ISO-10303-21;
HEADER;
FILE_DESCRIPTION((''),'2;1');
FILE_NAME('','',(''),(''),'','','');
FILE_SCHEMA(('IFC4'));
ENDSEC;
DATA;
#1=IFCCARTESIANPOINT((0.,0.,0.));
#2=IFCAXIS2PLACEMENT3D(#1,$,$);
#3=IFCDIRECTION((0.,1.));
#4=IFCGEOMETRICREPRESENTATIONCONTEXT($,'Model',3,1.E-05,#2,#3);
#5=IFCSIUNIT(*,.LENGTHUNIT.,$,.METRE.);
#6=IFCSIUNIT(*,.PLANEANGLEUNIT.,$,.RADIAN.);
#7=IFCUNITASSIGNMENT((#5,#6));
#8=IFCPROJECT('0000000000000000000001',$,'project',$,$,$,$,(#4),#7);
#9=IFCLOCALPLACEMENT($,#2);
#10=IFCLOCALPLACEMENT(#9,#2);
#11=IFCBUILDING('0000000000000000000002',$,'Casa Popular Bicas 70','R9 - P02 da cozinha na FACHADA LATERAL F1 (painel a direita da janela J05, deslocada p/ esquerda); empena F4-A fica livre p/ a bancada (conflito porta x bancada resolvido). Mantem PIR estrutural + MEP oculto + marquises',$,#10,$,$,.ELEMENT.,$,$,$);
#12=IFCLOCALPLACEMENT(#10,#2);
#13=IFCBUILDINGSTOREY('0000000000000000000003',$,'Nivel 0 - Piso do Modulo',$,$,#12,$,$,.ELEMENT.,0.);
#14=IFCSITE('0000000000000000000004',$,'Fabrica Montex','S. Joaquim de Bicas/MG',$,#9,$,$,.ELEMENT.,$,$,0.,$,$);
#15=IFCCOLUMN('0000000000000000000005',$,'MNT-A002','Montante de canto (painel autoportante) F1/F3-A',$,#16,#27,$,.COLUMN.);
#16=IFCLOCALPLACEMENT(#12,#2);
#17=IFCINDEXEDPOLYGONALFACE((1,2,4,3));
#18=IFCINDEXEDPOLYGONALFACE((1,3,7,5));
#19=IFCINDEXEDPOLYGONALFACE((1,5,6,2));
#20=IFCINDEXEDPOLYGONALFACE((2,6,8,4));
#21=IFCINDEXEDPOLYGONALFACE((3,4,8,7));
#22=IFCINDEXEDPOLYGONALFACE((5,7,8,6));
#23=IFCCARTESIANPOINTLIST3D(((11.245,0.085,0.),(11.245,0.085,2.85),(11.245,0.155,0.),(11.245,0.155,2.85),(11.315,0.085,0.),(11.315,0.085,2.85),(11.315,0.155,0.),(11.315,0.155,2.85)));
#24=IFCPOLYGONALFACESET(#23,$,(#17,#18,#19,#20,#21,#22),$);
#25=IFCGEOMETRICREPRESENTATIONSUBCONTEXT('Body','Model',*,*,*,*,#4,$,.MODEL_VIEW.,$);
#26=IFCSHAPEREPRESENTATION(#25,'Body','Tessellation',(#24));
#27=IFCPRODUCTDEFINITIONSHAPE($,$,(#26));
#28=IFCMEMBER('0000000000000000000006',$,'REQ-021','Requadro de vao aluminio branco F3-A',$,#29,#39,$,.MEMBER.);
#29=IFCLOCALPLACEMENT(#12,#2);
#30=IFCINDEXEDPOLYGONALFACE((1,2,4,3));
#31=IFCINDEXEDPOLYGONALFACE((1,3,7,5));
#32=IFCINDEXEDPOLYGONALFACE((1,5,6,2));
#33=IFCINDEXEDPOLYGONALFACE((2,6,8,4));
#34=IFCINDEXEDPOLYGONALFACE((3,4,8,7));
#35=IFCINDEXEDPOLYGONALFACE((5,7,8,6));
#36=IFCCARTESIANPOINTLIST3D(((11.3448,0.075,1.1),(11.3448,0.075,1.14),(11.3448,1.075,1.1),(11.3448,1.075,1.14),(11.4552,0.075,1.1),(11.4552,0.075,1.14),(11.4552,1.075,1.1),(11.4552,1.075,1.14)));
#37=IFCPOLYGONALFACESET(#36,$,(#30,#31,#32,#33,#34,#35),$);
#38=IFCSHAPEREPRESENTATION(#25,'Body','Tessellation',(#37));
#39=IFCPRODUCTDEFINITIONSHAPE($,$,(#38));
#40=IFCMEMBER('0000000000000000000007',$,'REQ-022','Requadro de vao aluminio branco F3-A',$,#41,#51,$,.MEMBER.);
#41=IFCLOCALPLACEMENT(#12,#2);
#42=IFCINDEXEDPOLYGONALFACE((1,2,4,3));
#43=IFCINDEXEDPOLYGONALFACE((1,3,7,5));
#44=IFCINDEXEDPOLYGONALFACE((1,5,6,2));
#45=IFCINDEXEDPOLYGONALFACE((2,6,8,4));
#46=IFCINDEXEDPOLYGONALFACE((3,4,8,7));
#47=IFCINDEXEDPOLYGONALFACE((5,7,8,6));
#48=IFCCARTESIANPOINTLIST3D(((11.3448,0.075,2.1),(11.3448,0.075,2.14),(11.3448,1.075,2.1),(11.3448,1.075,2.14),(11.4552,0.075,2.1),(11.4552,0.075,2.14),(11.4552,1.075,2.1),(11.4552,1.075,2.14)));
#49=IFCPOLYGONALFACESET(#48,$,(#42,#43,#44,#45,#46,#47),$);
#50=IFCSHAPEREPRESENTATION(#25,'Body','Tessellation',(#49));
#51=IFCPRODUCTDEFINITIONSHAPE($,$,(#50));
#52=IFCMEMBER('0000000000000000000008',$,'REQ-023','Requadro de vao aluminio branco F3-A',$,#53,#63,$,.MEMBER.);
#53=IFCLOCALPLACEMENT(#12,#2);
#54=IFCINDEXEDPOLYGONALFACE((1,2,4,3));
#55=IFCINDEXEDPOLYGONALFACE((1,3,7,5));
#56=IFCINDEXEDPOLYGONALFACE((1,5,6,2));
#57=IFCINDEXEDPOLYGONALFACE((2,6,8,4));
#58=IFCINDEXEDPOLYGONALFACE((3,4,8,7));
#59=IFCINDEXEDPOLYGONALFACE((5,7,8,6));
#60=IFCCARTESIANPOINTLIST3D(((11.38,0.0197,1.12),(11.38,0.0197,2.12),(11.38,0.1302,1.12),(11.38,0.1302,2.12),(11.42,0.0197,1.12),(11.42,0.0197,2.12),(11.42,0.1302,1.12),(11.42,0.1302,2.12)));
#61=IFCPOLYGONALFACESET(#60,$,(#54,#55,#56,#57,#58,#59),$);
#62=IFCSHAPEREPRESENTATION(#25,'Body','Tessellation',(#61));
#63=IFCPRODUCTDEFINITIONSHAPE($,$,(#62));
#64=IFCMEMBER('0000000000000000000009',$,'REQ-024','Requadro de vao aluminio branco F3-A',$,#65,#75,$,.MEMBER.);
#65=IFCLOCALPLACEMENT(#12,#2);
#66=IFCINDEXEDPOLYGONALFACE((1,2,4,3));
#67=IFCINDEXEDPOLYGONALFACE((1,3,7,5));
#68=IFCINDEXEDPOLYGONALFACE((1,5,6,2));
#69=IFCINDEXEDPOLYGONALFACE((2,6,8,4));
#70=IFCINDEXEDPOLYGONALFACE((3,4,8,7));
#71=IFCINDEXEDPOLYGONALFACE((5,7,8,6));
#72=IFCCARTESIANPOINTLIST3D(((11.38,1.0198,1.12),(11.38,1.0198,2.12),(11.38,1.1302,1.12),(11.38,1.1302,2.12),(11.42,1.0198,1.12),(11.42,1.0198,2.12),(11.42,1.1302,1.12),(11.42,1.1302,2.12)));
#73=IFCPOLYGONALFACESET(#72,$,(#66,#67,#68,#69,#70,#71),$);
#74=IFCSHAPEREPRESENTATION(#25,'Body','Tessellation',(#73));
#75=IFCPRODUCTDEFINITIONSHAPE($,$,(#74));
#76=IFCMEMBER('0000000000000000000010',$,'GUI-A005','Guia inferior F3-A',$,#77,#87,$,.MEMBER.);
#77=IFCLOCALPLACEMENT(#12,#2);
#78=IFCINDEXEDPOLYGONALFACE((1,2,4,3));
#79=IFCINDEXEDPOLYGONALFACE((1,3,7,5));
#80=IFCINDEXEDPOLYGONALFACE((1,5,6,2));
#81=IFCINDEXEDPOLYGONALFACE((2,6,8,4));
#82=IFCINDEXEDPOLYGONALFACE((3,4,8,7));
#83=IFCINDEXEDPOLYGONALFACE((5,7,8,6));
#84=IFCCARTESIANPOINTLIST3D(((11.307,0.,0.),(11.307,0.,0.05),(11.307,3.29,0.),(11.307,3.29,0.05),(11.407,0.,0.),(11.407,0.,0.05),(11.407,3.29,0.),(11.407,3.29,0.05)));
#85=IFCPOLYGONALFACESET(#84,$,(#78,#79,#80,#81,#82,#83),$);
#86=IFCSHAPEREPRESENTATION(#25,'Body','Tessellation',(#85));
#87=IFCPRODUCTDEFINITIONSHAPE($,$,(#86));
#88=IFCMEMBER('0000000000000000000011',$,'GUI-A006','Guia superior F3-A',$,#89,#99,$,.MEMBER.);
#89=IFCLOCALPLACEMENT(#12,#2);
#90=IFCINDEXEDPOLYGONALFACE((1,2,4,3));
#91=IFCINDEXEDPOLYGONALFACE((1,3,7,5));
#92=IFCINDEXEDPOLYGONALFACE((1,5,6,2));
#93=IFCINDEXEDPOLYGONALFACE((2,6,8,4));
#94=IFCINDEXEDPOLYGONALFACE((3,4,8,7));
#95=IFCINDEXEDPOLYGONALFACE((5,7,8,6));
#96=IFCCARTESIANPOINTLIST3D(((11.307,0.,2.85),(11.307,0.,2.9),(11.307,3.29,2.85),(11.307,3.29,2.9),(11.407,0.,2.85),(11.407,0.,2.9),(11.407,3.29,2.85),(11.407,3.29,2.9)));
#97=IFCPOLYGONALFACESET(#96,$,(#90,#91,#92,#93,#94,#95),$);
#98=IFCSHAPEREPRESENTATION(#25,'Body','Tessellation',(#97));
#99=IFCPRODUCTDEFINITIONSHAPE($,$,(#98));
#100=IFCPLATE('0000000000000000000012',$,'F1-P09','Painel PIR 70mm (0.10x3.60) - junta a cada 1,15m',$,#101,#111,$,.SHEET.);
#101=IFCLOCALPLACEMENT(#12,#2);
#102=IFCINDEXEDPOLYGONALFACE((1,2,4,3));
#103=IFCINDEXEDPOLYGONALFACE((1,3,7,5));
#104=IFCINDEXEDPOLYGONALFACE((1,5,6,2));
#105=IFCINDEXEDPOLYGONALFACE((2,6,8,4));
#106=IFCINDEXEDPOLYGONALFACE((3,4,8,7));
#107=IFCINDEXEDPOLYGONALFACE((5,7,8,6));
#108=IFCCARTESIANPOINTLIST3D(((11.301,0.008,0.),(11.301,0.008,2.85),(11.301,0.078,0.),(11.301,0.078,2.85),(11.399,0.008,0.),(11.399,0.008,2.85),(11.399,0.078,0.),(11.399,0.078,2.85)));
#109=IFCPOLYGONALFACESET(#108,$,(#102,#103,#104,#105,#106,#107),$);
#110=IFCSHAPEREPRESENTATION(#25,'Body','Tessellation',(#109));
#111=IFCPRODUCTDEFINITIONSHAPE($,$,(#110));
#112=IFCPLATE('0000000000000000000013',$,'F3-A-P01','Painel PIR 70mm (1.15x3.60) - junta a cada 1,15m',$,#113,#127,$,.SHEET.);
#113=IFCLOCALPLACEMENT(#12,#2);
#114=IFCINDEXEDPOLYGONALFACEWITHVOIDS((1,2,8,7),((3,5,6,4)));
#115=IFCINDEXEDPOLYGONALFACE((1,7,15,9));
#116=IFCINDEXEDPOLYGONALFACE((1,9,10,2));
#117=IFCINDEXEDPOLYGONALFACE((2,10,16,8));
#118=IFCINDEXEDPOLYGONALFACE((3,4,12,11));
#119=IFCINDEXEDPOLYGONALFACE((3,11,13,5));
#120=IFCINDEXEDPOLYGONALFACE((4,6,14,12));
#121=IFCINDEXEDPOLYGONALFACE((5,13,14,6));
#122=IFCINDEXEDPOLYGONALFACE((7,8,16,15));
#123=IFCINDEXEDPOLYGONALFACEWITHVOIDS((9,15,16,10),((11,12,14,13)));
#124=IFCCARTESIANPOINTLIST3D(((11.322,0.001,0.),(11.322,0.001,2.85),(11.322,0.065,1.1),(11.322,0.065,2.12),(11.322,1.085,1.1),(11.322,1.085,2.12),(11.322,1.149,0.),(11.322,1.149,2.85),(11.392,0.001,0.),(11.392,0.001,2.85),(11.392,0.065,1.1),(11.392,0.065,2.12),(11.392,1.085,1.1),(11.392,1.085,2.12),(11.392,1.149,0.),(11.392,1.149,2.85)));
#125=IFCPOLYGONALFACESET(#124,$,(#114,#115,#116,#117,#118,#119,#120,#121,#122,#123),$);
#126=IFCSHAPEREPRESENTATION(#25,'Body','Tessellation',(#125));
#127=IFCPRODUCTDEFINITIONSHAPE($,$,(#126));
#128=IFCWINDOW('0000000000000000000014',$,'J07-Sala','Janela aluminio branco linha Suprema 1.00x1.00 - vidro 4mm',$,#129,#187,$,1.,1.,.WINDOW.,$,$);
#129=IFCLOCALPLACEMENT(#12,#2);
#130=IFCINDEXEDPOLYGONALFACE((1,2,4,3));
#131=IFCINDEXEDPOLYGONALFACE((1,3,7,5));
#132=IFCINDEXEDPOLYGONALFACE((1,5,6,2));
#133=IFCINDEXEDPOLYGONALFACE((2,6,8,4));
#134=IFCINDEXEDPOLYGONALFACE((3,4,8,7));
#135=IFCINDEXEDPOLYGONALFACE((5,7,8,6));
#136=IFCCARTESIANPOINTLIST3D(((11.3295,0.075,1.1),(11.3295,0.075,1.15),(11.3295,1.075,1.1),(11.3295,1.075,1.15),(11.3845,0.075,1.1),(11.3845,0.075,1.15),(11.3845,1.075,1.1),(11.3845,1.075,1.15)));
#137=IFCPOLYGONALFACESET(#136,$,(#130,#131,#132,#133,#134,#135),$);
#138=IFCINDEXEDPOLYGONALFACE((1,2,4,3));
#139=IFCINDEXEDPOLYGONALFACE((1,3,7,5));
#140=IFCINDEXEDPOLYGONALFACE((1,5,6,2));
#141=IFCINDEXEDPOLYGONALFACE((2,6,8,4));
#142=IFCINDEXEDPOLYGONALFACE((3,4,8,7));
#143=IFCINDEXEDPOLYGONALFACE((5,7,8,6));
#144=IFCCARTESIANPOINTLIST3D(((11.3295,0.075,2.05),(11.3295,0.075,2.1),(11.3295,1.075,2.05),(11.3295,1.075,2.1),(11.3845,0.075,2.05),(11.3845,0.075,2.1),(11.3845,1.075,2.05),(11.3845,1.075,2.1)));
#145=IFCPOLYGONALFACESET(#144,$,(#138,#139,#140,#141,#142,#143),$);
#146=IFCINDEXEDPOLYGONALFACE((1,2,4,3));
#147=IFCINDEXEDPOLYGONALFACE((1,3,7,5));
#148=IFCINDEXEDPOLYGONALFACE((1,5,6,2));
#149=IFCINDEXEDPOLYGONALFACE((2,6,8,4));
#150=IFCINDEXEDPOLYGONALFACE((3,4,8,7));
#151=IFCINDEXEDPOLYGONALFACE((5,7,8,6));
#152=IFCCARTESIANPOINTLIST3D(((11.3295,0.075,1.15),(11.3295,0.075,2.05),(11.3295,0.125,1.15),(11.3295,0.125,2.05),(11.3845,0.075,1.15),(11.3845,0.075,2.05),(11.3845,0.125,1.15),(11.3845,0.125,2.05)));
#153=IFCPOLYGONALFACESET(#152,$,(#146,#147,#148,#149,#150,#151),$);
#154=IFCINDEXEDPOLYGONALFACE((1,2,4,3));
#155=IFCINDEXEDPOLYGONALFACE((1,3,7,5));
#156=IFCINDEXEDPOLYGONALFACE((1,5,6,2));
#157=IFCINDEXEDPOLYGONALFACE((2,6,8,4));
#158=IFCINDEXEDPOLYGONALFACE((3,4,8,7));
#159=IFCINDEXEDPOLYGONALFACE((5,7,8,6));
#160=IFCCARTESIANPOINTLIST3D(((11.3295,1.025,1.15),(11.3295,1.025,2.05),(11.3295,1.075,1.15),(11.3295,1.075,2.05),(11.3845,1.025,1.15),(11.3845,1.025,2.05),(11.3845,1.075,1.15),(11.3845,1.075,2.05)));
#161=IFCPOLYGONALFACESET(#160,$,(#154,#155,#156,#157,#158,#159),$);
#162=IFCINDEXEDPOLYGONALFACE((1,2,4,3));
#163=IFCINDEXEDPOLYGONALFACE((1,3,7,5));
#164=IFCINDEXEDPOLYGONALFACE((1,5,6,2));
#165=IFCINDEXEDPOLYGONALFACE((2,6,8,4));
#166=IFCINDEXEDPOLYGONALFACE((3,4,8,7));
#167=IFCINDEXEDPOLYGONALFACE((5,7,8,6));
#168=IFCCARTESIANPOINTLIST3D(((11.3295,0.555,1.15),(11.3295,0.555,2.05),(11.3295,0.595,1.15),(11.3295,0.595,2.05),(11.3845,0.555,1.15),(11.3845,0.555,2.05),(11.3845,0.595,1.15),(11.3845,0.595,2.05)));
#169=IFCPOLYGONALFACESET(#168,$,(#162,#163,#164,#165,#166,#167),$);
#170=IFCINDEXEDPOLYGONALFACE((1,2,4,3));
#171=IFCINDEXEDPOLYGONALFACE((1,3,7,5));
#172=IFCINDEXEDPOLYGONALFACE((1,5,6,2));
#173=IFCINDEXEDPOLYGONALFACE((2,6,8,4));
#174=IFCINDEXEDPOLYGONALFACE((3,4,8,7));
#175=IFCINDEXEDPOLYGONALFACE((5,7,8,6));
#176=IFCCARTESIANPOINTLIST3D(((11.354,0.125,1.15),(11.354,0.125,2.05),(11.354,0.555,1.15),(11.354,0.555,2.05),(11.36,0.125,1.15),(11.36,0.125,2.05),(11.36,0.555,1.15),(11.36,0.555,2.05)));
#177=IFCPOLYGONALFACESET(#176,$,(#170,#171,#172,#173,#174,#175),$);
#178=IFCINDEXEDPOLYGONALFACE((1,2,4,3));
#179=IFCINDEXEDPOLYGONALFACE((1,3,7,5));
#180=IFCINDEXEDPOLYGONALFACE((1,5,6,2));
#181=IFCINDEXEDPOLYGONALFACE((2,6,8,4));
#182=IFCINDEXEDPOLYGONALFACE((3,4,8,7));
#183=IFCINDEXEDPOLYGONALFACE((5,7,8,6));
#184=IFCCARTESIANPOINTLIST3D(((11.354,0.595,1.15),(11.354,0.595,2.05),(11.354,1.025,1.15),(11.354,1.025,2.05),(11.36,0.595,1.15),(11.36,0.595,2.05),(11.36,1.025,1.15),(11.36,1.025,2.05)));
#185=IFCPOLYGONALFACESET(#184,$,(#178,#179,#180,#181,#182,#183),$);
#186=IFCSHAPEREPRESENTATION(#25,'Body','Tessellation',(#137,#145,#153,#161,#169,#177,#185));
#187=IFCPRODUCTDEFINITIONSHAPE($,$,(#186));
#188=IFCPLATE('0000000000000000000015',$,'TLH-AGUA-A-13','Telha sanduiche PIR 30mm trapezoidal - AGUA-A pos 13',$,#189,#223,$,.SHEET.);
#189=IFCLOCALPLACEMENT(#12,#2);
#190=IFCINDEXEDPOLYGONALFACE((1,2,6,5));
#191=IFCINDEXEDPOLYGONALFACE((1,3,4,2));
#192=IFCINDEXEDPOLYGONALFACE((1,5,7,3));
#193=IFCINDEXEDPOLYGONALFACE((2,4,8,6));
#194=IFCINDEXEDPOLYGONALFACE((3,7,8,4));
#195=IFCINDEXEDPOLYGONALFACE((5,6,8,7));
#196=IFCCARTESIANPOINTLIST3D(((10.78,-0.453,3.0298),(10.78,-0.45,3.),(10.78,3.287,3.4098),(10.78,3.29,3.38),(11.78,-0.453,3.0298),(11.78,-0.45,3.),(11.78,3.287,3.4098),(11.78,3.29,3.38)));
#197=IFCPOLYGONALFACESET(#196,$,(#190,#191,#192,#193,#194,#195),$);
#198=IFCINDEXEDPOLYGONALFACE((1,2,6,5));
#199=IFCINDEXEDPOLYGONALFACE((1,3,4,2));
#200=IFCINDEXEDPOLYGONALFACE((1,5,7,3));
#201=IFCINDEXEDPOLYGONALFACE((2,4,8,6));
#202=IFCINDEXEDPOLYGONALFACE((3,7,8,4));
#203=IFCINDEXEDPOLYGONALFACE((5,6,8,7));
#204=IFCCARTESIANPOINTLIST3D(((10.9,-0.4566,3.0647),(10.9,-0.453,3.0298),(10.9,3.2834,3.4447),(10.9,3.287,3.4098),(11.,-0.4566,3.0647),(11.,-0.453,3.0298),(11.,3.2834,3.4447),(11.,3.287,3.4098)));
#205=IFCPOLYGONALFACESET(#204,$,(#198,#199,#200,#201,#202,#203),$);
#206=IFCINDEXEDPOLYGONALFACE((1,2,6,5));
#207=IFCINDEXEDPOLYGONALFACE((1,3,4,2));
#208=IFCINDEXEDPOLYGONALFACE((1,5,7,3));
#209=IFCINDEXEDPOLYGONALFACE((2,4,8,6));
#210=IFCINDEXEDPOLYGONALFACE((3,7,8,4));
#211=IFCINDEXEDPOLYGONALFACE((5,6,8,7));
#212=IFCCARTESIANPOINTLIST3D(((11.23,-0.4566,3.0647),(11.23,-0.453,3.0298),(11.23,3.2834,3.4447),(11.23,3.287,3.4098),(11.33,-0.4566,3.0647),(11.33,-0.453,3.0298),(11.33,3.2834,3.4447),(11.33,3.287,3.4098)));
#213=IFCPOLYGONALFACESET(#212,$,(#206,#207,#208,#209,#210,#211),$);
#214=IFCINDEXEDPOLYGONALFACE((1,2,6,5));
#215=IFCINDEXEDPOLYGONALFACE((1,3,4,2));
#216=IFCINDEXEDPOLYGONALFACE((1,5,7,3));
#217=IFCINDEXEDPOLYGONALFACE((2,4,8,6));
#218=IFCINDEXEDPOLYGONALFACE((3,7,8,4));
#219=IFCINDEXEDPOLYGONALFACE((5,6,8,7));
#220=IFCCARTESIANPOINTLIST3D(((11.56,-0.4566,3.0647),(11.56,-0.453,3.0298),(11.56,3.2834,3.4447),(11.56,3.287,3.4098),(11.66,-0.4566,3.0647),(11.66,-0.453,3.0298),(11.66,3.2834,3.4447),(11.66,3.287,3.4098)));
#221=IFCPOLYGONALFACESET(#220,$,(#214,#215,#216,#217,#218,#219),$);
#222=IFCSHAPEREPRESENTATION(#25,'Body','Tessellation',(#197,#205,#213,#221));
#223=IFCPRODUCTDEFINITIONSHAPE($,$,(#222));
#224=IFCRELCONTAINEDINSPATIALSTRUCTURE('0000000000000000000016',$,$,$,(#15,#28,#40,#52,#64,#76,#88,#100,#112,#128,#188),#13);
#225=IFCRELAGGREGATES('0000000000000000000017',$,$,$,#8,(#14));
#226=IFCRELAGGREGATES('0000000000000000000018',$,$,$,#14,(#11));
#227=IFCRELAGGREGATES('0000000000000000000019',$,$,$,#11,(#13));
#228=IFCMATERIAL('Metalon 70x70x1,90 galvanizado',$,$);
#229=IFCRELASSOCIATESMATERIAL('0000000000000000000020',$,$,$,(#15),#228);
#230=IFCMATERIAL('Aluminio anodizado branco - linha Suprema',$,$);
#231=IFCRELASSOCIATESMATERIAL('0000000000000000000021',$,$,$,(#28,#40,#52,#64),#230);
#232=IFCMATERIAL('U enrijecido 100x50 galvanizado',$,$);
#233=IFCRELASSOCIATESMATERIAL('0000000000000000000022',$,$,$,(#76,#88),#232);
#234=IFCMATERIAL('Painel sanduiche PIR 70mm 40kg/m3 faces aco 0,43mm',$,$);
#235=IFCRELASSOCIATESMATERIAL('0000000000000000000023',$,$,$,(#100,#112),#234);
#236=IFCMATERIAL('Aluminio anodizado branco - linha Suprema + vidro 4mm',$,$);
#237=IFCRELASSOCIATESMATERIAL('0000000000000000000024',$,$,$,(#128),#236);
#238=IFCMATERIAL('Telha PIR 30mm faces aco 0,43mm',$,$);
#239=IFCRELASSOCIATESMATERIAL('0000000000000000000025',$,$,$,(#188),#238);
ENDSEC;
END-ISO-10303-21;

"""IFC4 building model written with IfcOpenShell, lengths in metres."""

from ifc_helpers import new_model, si_unit, direction, frame, frame_2d, origin, origin_2d, place, context, subcontext, project, spatial, rectangle, extrude, material, element, fill, save


model = new_model("IFC4")

# Units and contexts
model_context = context("Model", 3, precision=1e-05, world=origin(), true_north=direction((0.0, 1.0)))
body_context = subcontext(model_context, "Body", "Model", "MODEL_VIEW")
ifc_project = project(units=[si_unit("LENGTHUNIT", "METRE"), si_unit("PLANEANGLEUNIT", "RADIAN")], contexts=[model_context])

# Site, building, storey
site_placement = place(None, origin())
site = spatial("IfcSite", under=ifc_project, at=site_placement, Name="Fabrica Montex", Description="S. Joaquim de Bicas/MG", CompositionType="ELEMENT", RefElevation=0.0)
building_placement = place(site_placement, origin())
building = spatial("IfcBuilding", under=site, at=building_placement, Name="Casa Popular Bicas 70", Description="R9 - P02 da cozinha na FACHADA LATERAL F1 (painel a direita da janela J05, deslocada p/ esquerda); empena F4-A fica livre p/ a bancada (conflito porta x bancada resolvido). Mantem PIR estrutural + MEP oculto + marquises", CompositionType="ELEMENT")
storey_placement = place(building_placement, origin())
storey = spatial("IfcBuildingStorey", under=building, at=storey_placement, Name="Nivel 0 - Piso do Modulo", CompositionType="ELEMENT", Elevation=0.0)

# Column
ifc_material_1 = material(Name="Metalon 70x70x1,90 galvanizado")
column_placement = place(storey_placement, frame((11.28, 0.12, 0.0)))
element("IfcColumn", 1, at=column_placement, inside=storey, material=ifc_material_1, Name="MNT-A002", Description="Montante de canto (painel autoportante) F1/F3-A", PredefinedType="COLUMN", context=body_context, shape_type="SweptSolid", body=[
    extrude(rectangle(XDim=0.07, YDim=0.07, at=origin_2d()), origin(), (0.0, 0.0, 1.0), 2.85),
])

# Members
ifc_material_2 = material(Name="Aluminio anodizado branco - linha Suprema")
for number, where, z_axis, x_axis, name in (
    (2, (11.4, 0.075, 1.12), (0.0, 1.0, 0.0), (0.0, 0.0, 1.0), "REQ-021"),
    (3, (11.4, 0.075, 2.12), (0.0, 1.0, 0.0), (0.0, 0.0, 1.0), "REQ-022"),
    (4, (11.4, 0.075, 1.12), (0.0, 0.0, 1.0), (1.0, 0.0, 0.0), "REQ-023"),
    (5, (11.4, 1.075, 1.12), (0.0, 0.0, 1.0), (1.0, 0.0, 0.0), "REQ-024"),
):
    element("IfcMember", number, at=place(storey_placement, frame(where, z_axis=z_axis, x_axis=x_axis)), inside=storey, material=ifc_material_2, Name=name, Description="Requadro de vao aluminio branco F3-A", PredefinedType="MEMBER", context=body_context, shape_type="SweptSolid", body=[
        extrude(rectangle(XDim=0.04, YDim=0.1105, at=origin_2d()), origin(), (0.0, 0.0, 1.0), 1.0),
    ])
ifc_material_3 = material(Name="U enrijecido 100x50 galvanizado")
for number, where, z_axis, x_axis, name, description in (
    (6, (11.357, 0.0, 0.025), (0.0, 1.0, 0.0), (0.0, 0.0, 1.0), "GUI-A005", "Guia inferior F3-A"),
    (7, (11.357, 0.0, 2.875), (0.0, 1.0, 0.0), (0.0, 0.0, 1.0), "GUI-A006", "Guia superior F3-A"),
):
    element("IfcMember", number, at=place(storey_placement, frame(where, z_axis=z_axis, x_axis=x_axis)), inside=storey, material=ifc_material_3, Name=name, Description=description, PredefinedType="MEMBER", context=body_context, shape_type="SweptSolid", body=[
        extrude(rectangle(XDim=0.05, YDim=0.1, at=origin_2d()), origin(), (0.0, 0.0, 1.0), 3.29),
    ])

# Plate
ifc_material_4 = material(Name="Painel sanduiche PIR 70mm 40kg/m3 faces aco 0,43mm")
plate_1_placement = place(storey_placement, frame((11.301, 0.043, 0.0), x_axis=(1.0, 0.0, 0.0)))
element("IfcPlate", 8, at=plate_1_placement, inside=storey, material=ifc_material_4, Name="F1-P09", Description="Painel PIR 70mm (0.10x3.60) - junta a cada 1,15m", PredefinedType="SHEET", context=body_context, shape_type="SweptSolid", body=[
    extrude(rectangle(XDim=0.098, YDim=0.07, at=frame_2d((0.049, 0.0))), origin(), (0.0, 0.0, 1.0), 2.85),
])

# Plate, opening, window
plate_2_placement = place(storey_placement, frame((11.357, 0.001, 0.0), x_axis=(0.0, 1.0, 0.0)))
plate_2 = element("IfcPlate", 9, at=plate_2_placement, inside=storey, material=ifc_material_4, Name="F3-A-P01", Description="Painel PIR 70mm (1.15x3.60) - junta a cada 1,15m", PredefinedType="SHEET", context=body_context, shape_type="SweptSolid", body=[
    extrude(rectangle(XDim=1.148, YDim=0.07, at=frame_2d((0.574, 0.0))), origin(), (0.0, 0.0, 1.0), 2.85),
])
opening_1_placement = place(storey_placement, frame((11.357, 0.075, 1.1), x_axis=(0.0, 1.0, 0.0)))
opening_1 = element("IfcOpeningElement", 10, at=opening_1_placement, cuts=plate_2, PredefinedType="OPENING", context=body_context, shape_type="SweptSolid", body=[
    extrude(rectangle(XDim=1.02, YDim=0.3, at=frame_2d((0.5, 0.0))), origin(), (0.0, 0.0, 1.0), 1.02),
])
ifc_material_5 = material(Name="Aluminio anodizado branco - linha Suprema + vidro 4mm")
window_placement = place(storey_placement, frame((11.357, 0.075, 1.1), x_axis=(0.0, 1.0, 0.0)))
window = element("IfcWindow", 11, at=window_placement, inside=storey, material=ifc_material_5, Name="J07-Sala", Description="Janela aluminio branco linha Suprema 1.00x1.00 - vidro 4mm", OverallHeight=1.0, OverallWidth=1.0, PredefinedType="WINDOW", context=body_context, shape_type="SweptSolid", body=[
    extrude(rectangle(XDim=1.0, YDim=0.055, at=frame_2d((0.5, 0.0))), origin(), (0.0, 0.0, 1.0), 0.05),
    extrude(rectangle(XDim=1.0, YDim=0.055, at=frame_2d((0.5, 0.0))), frame((0.0, 0.0, 0.95)), (0.0, 0.0, 1.0), 0.05),
    extrude(rectangle(XDim=0.05, YDim=0.055, at=frame_2d((0.025, 0.0))), frame((0.0, 0.0, 0.05)), (0.0, 0.0, 1.0), 0.9),
    extrude(rectangle(XDim=0.05, YDim=0.055, at=frame_2d((0.975, 0.0))), frame((0.0, 0.0, 0.05)), (0.0, 0.0, 1.0), 0.9),
    extrude(rectangle(XDim=0.04, YDim=0.055, at=frame_2d((0.5, 0.0))), frame((0.0, 0.0, 0.05)), (0.0, 0.0, 1.0), 0.9),
    extrude(rectangle(XDim=0.43, YDim=0.006, at=frame_2d((0.265, 0.0))), frame((0.0, 0.0, 0.05)), (0.0, 0.0, 1.0), 0.9),
    extrude(rectangle(XDim=0.43, YDim=0.006, at=frame_2d((0.735, 0.0))), frame((0.0, 0.0, 0.05)), (0.0, 0.0, 1.0), 0.9),
])
fill(opening_1, window)

# Plate
ifc_material_6 = material(Name="Telha PIR 30mm faces aco 0,43mm")
for number, where, z_axis, x_axis, name in (
    (12, (10.78, -0.45, 3.0), (0.0, -0.101084, 0.994878), (1.0, 0.0, 0.0), "TLH-AGUA-A-13"),
):
    element("IfcPlate", number, at=place(storey_placement, frame(where, z_axis=z_axis, x_axis=x_axis)), inside=storey, material=ifc_material_6, Name=name, Description="Telha sanduiche PIR 30mm trapezoidal - AGUA-A pos 13", PredefinedType="SHEET", context=body_context, shape_type="SweptSolid", body=[
        extrude(rectangle(XDim=1.0, YDim=3.7593, at=frame_2d((0.5, 1.8796))), origin(), (0.0, 0.0, 1.0), 0.03),
        extrude(rectangle(XDim=0.1, YDim=3.7593, at=frame_2d((0.17, 1.8796))), frame((0.0, 0.0, 0.03)), (0.0, 0.0, 1.0), 0.035),
        extrude(rectangle(XDim=0.1, YDim=3.7593, at=frame_2d((0.5, 1.8796))), frame((0.0, 0.0, 0.03)), (0.0, 0.0, 1.0), 0.035),
        extrude(rectangle(XDim=0.1, YDim=3.7593, at=frame_2d((0.83, 1.8796))), frame((0.0, 0.0, 0.03)), (0.0, 0.0, 1.0), 0.035),
    ])

save(model, "model.ifc")
